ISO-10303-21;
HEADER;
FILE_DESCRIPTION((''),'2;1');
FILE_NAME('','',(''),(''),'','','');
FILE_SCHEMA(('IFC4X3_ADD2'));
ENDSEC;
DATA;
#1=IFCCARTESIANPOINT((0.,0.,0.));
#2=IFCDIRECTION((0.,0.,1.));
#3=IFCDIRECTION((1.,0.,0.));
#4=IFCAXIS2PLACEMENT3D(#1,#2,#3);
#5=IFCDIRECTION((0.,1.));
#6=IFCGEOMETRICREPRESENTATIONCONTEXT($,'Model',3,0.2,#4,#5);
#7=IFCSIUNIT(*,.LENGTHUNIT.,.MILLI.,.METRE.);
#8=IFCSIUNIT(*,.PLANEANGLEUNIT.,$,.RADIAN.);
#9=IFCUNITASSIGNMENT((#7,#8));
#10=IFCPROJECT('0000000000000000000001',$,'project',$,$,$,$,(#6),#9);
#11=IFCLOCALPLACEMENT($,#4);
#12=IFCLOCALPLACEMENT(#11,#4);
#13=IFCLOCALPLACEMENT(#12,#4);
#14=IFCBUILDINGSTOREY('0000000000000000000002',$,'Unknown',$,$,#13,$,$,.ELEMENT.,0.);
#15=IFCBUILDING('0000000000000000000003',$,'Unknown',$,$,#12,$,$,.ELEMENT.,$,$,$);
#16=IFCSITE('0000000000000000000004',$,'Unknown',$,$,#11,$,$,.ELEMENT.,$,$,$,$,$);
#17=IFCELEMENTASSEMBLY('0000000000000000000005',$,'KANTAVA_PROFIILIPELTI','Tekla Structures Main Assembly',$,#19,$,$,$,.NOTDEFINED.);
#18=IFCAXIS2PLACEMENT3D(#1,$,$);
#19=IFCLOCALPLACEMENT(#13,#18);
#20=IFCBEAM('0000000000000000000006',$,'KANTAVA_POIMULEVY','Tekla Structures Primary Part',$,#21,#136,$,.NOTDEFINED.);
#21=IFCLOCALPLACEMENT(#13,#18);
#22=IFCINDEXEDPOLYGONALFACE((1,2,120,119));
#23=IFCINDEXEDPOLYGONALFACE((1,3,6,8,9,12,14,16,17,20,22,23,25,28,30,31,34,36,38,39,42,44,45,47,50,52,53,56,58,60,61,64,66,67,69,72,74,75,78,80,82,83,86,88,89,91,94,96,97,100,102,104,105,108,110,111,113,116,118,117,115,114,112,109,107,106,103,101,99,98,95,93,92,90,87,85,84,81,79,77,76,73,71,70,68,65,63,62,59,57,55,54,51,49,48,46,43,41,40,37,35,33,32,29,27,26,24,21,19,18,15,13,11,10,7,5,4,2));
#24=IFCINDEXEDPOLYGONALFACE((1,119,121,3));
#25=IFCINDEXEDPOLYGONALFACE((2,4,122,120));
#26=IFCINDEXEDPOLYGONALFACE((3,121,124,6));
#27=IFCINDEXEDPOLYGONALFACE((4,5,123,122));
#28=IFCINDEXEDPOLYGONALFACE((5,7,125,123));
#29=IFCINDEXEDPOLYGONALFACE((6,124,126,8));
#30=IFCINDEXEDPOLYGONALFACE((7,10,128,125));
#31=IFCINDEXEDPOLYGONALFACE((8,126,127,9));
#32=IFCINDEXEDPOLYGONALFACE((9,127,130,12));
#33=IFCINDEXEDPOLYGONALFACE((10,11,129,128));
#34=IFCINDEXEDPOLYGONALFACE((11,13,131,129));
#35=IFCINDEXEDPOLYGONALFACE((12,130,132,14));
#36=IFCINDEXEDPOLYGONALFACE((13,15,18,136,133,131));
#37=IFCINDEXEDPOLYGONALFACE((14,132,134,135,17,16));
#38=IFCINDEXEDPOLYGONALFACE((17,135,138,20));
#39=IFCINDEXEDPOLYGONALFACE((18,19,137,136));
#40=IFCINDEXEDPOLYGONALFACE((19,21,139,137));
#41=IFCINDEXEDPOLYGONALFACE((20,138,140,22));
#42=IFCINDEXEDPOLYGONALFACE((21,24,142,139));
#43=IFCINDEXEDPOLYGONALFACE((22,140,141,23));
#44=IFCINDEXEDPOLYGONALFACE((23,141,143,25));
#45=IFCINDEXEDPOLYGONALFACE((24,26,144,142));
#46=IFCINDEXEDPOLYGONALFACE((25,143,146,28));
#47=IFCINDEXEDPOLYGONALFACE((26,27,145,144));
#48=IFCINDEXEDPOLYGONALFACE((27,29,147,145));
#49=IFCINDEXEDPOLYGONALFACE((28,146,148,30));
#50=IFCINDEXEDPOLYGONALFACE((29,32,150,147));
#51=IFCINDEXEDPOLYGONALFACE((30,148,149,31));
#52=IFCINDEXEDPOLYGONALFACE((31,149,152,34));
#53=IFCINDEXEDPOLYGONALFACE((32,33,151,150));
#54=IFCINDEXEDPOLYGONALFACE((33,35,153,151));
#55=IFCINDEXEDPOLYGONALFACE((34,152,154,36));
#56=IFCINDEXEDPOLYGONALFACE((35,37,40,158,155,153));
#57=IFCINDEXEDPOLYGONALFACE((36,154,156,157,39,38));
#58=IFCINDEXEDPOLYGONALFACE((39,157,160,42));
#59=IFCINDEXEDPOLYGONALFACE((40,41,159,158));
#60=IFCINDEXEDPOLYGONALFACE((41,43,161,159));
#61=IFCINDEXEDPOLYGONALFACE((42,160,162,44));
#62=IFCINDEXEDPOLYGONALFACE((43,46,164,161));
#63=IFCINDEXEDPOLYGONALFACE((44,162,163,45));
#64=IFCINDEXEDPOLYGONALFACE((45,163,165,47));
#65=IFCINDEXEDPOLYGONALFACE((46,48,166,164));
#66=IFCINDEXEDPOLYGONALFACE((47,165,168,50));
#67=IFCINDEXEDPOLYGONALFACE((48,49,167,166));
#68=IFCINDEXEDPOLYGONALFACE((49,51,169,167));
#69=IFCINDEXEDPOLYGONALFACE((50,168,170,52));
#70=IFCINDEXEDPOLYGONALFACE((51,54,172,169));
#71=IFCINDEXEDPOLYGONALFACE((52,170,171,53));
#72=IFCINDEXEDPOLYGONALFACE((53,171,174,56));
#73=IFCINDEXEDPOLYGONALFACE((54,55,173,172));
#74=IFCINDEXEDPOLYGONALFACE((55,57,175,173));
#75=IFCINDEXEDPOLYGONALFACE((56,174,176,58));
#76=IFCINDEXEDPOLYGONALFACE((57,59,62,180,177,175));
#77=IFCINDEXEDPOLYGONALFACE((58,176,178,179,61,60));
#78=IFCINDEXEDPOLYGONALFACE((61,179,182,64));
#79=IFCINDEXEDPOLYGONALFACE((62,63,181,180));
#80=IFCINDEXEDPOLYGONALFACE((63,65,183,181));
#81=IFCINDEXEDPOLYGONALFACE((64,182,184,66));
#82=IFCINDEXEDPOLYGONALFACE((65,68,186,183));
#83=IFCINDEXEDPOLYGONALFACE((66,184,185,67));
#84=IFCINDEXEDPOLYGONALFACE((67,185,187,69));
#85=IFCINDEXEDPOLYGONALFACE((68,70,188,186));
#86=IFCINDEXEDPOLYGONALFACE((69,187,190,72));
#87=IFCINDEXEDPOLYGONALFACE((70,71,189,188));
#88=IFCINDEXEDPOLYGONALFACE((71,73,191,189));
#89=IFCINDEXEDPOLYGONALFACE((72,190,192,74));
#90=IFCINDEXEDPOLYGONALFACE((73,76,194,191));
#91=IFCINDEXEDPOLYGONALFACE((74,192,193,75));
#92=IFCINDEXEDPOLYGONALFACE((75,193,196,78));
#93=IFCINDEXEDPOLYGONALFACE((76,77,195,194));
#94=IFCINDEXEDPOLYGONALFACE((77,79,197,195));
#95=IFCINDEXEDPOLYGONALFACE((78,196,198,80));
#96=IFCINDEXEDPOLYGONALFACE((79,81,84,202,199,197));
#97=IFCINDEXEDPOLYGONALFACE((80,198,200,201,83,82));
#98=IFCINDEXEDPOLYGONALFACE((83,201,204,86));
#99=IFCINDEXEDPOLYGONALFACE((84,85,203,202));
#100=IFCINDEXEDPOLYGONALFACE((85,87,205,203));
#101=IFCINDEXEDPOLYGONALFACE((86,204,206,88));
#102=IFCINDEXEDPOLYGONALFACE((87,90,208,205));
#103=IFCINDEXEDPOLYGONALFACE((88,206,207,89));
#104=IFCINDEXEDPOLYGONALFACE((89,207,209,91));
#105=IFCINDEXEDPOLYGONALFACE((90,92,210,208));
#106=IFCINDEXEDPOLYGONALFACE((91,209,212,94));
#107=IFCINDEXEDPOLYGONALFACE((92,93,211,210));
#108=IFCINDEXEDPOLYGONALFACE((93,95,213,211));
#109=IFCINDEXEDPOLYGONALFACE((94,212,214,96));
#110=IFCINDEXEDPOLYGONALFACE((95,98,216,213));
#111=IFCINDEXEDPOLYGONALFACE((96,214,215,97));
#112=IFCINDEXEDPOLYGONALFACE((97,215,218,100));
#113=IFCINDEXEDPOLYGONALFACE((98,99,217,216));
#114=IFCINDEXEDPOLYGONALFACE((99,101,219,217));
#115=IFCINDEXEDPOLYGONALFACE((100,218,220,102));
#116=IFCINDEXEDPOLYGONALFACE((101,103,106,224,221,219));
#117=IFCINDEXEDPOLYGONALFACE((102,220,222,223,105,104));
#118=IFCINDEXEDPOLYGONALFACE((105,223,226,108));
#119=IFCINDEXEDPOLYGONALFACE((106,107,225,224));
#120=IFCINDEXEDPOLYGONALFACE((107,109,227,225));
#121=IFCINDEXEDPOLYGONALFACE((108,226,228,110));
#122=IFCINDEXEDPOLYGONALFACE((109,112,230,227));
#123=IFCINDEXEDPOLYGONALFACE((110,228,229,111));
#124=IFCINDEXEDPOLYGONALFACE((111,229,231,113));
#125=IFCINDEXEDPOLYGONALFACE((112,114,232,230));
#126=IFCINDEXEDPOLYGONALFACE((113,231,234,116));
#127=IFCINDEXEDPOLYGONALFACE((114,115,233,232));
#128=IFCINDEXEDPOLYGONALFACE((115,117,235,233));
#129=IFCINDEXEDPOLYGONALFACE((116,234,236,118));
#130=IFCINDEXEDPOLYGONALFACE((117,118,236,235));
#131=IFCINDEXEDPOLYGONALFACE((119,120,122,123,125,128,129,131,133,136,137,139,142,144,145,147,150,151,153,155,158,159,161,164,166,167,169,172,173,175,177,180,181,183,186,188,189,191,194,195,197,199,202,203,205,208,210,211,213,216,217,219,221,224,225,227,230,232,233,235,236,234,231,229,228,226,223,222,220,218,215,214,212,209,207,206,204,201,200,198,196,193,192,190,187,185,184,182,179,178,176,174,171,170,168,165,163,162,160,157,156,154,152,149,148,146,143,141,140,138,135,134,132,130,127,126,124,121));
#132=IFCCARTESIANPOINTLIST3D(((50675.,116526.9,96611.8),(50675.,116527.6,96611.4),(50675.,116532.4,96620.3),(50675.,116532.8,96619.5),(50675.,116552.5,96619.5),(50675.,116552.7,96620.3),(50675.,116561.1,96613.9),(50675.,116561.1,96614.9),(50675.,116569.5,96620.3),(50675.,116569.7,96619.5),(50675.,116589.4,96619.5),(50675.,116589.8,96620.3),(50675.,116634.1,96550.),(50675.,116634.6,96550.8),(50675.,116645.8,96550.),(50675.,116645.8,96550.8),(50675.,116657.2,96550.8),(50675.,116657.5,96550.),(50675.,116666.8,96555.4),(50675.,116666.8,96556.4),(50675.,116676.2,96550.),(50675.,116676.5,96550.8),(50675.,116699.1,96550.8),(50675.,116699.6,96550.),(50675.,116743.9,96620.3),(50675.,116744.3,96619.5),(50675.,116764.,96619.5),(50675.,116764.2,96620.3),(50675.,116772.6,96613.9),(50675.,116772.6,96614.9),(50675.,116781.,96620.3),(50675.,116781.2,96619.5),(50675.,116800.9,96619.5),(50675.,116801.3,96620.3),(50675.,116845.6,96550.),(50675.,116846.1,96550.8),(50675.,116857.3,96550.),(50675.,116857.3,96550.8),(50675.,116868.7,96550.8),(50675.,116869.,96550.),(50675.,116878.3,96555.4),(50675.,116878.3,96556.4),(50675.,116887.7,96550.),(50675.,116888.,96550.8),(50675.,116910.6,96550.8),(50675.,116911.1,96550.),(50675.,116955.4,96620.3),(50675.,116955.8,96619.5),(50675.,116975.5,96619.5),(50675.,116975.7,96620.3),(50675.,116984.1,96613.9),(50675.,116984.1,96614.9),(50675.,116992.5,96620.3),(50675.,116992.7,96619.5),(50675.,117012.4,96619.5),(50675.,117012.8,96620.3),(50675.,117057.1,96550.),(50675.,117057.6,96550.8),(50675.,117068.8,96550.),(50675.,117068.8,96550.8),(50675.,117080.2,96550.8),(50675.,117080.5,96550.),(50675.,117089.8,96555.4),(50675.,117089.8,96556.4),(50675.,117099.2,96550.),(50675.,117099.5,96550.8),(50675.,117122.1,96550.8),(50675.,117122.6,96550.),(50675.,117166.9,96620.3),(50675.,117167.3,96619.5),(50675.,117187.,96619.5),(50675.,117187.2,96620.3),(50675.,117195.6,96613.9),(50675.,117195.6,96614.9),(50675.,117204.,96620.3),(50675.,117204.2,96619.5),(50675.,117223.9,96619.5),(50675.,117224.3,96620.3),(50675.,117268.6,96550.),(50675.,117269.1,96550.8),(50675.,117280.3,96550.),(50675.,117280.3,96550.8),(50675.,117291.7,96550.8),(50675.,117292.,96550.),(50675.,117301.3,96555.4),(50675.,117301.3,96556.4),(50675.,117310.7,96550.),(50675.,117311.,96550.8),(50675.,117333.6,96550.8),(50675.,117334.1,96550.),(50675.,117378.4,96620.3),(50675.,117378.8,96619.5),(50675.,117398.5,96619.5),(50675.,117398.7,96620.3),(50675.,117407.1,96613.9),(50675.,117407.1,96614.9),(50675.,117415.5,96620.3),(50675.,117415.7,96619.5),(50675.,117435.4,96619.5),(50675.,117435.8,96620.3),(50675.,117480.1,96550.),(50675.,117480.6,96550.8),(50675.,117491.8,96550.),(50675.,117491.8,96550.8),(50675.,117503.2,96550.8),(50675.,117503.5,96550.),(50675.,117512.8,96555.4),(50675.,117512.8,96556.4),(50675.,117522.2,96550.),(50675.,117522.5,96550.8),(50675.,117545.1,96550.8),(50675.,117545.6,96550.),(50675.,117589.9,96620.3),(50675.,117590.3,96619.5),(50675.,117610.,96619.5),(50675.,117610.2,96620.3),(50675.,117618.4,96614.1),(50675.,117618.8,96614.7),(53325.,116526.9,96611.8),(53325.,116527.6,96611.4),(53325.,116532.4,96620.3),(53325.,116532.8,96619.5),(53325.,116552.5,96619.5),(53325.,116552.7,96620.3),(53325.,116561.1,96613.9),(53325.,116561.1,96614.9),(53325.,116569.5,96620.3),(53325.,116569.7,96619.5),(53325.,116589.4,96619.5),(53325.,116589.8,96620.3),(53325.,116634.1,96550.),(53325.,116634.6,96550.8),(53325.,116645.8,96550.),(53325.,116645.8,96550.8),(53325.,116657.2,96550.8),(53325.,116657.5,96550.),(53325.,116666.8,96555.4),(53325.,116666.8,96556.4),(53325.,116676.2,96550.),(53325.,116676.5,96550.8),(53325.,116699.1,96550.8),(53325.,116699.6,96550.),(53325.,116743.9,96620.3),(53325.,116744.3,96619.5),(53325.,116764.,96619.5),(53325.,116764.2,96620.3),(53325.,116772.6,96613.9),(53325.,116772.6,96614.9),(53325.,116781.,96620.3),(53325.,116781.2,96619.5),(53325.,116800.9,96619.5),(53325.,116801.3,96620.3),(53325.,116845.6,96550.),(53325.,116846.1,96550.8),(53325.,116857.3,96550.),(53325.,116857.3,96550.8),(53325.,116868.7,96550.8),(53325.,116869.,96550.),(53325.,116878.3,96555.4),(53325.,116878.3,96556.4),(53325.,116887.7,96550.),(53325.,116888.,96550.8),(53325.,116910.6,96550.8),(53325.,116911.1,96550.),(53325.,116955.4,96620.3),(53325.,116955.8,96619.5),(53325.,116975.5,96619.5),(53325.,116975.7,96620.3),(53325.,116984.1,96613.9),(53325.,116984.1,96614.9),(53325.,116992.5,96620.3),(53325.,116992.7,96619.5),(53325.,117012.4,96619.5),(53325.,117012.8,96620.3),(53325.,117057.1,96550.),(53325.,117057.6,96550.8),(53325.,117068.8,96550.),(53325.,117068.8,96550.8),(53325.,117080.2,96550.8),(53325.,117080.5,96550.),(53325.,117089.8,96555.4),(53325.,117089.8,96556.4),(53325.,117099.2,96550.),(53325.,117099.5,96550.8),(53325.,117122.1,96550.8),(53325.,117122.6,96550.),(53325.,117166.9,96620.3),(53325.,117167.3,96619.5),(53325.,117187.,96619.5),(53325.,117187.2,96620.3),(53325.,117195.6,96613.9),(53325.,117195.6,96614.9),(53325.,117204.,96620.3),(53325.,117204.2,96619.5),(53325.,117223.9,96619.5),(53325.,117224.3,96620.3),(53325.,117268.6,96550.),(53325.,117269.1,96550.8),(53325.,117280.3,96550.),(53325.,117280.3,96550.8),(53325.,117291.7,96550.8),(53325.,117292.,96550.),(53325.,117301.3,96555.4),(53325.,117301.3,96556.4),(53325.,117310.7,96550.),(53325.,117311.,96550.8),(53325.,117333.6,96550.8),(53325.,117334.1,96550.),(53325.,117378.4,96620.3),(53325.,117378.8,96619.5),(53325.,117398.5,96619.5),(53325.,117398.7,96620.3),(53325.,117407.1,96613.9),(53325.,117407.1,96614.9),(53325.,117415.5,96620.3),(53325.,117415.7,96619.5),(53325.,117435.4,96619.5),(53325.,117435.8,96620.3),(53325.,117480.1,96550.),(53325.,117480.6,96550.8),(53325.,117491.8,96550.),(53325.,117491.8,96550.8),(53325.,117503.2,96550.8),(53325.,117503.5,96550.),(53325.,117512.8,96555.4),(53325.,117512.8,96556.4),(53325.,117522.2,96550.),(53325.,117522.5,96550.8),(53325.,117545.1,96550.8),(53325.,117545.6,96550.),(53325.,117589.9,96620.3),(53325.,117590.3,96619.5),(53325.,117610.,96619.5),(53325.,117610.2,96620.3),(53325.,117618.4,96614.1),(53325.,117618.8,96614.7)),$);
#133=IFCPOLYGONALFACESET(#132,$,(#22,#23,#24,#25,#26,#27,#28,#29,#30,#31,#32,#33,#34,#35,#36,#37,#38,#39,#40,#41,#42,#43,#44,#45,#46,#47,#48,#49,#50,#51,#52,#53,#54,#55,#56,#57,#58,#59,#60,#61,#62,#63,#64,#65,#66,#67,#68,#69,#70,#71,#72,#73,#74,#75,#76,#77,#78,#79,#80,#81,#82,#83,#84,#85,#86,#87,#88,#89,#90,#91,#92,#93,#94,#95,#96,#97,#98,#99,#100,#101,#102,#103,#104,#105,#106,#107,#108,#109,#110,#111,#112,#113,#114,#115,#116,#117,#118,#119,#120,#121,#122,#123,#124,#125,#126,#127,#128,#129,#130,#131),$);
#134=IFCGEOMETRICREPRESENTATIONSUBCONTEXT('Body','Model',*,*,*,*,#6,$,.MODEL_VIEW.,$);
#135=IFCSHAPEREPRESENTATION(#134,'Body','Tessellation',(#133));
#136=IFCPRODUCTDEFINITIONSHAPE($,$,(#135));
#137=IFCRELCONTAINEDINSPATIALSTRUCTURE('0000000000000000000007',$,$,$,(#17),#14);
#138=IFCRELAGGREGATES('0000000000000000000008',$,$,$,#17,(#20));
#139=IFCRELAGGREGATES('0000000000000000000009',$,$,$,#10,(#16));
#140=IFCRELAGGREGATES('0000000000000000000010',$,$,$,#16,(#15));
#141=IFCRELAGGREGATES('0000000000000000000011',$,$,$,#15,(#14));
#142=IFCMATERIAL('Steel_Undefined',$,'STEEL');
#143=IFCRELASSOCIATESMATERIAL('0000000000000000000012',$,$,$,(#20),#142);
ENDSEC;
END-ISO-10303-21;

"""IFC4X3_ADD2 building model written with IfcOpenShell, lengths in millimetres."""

from ifc_helpers import new_model, si_unit, direction, frame, origin_with_axes, place, context, subcontext, project, spatial, line, indexed_curve, outline, extrude, material, element, aggregate, save


model = new_model("IFC4X3_ADD2")

# Units and contexts
model_context = context("Model", 3, precision=0.2, world=origin_with_axes(), true_north=direction((0.0, 1.0)))
body_context = subcontext(model_context, "Body", "Model", "MODEL_VIEW")
ifc_project = project(units=[si_unit("LENGTHUNIT", "METRE", prefix="MILLI"), si_unit("PLANEANGLEUNIT", "RADIAN")], contexts=[model_context])

# Site, building, storey
site_placement = place(None, origin_with_axes())
site = spatial("IfcSite", under=ifc_project, at=site_placement, Name="Unknown", CompositionType="ELEMENT")
building_placement = place(site_placement, origin_with_axes())
building = spatial("IfcBuilding", under=site, at=building_placement, Name="Unknown", CompositionType="ELEMENT")
storey_placement = place(building_placement, origin_with_axes())
storey = spatial("IfcBuildingStorey", under=building, at=storey_placement, Name="Unknown", CompositionType="ELEMENT", Elevation=0.0)

# Element assembly, beam
ifc_material_1 = material(Name="Steel_Undefined", Category="STEEL")
assembly_1_placement = place(storey_placement, frame((53325.0, 117089.8, 96585.2), z_axis=(0.0, 1.0, 0.0), x_axis=(-1.0, 0.0, 0.0)))
assembly_1 = element("IfcElementAssembly", 1, at=assembly_1_placement, inside=storey, Name="KANTAVA_PROFIILIPELTI", Description="Tekla Structures Main Assembly", PredefinedType="NOTDEFINED")
beam_1_placement = place(assembly_1_placement, origin_with_axes())
beam_1 = element("IfcBeam", 2, at=beam_1_placement, material=ifc_material_1, Name="KANTAVA_POIMULEVY", Description="Tekla Structures Primary Part", PredefinedType="NOTDEFINED", context=body_context, shape_type="SolidModel", body=[
    extrude(outline(indexed_curve([(529.0, 29.6), (520.4, 35.1), (500.0, 35.1), (455.3, -34.4), (432.6, -34.4), (423.0, -28.8), (413.4, -34.4), (402.0, -34.4), (390.7, -34.4), (346.0, 35.1), (325.6, 35.1), (317.2, 29.7), (308.9, 35.1), (288.5, 35.1), (243.8, -34.4), (221.1, -34.4), (211.5, -28.8), (201.9, -34.4), (190.5, -34.4), (179.2, -34.4), (134.5, 35.1), (114.1, 35.1), (105.8, 29.7), (97.4, 35.1), (77.0, 35.1), (32.3, -34.4), (9.6, -34.4), (0.0, -28.8), (-9.6, -34.4), (-21.0, -34.4), (-32.3, -34.4), (-77.0, 35.1), (-97.4, 35.1), (-105.8, 29.7), (-114.1, 35.1), (-134.5, 35.1), (-179.2, -34.4), (-201.9, -34.4), (-211.5, -28.8), (-221.1, -34.4), (-232.5, -34.4), (-243.8, -34.4), (-288.5, 35.1), (-308.9, 35.1), (-317.2, 29.7), (-325.6, 35.1), (-346.0, 35.1), (-390.7, -34.4), (-413.4, -34.4), (-423.0, -28.8), (-432.6, -34.4), (-444.0, -34.4), (-455.3, -34.4), (-500.0, 35.1), (-520.4, 35.1), (-528.8, 29.7), (-537.1, 35.1), (-557.5, 35.1), (-562.9, 26.7), (-562.2, 26.2), (-557.0, 34.4), (-537.4, 34.4), (-528.8, 28.8), (-520.1, 34.4), (-500.5, 34.4), (-455.7, -35.1), (-444.0, -35.1), (-432.4, -35.1), (-423.0, -29.7), (-413.6, -35.1), (-390.3, -35.1), (-345.5, 34.4), (-325.9, 34.4), (-317.2, 28.8), (-308.6, 34.4), (-289.0, 34.4), (-244.2, -35.1), (-232.5, -35.1), (-220.9, -35.1), (-211.5, -29.7), (-202.1, -35.1), (-178.8, -35.1), (-134.0, 34.4), (-114.4, 34.4), (-105.8, 28.8), (-97.1, 34.4), (-77.5, 34.4), (-32.7, -35.1), (-21.0, -35.1), (-9.4, -35.1), (0.0, -29.7), (9.4, -35.1), (32.7, -35.1), (77.5, 34.4), (97.1, 34.4), (105.8, 28.8), (114.4, 34.4), (134.0, 34.4), (178.8, -35.1), (190.5, -35.1), (202.1, -35.1), (211.5, -29.7), (220.9, -35.1), (244.2, -35.1), (289.0, 34.4), (308.6, 34.4), (317.2, 28.8), (325.9, 34.4), (345.5, 34.4), (390.3, -35.1), (402.0, -35.1), (413.6, -35.1), (423.0, -29.7), (432.4, -35.1), (455.7, -35.1), (500.5, 34.4), (520.1, 34.4), (528.5, 28.9)], segments=[line(1, 2, 3, 4, 5, 6, 7, 8, 9, 10, 11, 12, 13, 14, 15, 16, 17, 18, 19, 20, 21, 22, 23, 24, 25, 26, 27, 28, 29, 30, 31, 32, 33, 34, 35, 36, 37, 38, 39, 40, 41, 42, 43, 44, 45, 46, 47, 48, 49, 50, 51, 52, 53, 54, 55, 56, 57, 58, 59, 60, 61, 62, 63, 64, 65, 66, 67, 68, 69, 70, 71, 72, 73, 74, 75, 76, 77, 78, 79, 80, 81, 82, 83, 84, 85, 86, 87, 88, 89, 90, 91, 92, 93, 94, 95, 96, 97, 98, 99, 100, 101, 102, 103, 104, 105, 106, 107, 108, 109, 110, 111, 112, 113, 114, 115, 116, 117, 118, 1)])), frame((0.0, 0.0, 0.0), z_axis=(-1.0, 0.0, 0.0), x_axis=(0.0, 0.0, 1.0)), (0.0, 0.0, -1.0), 2650.0),
])
aggregate(assembly_1, [beam_1])

save(model, "model.ifc")
